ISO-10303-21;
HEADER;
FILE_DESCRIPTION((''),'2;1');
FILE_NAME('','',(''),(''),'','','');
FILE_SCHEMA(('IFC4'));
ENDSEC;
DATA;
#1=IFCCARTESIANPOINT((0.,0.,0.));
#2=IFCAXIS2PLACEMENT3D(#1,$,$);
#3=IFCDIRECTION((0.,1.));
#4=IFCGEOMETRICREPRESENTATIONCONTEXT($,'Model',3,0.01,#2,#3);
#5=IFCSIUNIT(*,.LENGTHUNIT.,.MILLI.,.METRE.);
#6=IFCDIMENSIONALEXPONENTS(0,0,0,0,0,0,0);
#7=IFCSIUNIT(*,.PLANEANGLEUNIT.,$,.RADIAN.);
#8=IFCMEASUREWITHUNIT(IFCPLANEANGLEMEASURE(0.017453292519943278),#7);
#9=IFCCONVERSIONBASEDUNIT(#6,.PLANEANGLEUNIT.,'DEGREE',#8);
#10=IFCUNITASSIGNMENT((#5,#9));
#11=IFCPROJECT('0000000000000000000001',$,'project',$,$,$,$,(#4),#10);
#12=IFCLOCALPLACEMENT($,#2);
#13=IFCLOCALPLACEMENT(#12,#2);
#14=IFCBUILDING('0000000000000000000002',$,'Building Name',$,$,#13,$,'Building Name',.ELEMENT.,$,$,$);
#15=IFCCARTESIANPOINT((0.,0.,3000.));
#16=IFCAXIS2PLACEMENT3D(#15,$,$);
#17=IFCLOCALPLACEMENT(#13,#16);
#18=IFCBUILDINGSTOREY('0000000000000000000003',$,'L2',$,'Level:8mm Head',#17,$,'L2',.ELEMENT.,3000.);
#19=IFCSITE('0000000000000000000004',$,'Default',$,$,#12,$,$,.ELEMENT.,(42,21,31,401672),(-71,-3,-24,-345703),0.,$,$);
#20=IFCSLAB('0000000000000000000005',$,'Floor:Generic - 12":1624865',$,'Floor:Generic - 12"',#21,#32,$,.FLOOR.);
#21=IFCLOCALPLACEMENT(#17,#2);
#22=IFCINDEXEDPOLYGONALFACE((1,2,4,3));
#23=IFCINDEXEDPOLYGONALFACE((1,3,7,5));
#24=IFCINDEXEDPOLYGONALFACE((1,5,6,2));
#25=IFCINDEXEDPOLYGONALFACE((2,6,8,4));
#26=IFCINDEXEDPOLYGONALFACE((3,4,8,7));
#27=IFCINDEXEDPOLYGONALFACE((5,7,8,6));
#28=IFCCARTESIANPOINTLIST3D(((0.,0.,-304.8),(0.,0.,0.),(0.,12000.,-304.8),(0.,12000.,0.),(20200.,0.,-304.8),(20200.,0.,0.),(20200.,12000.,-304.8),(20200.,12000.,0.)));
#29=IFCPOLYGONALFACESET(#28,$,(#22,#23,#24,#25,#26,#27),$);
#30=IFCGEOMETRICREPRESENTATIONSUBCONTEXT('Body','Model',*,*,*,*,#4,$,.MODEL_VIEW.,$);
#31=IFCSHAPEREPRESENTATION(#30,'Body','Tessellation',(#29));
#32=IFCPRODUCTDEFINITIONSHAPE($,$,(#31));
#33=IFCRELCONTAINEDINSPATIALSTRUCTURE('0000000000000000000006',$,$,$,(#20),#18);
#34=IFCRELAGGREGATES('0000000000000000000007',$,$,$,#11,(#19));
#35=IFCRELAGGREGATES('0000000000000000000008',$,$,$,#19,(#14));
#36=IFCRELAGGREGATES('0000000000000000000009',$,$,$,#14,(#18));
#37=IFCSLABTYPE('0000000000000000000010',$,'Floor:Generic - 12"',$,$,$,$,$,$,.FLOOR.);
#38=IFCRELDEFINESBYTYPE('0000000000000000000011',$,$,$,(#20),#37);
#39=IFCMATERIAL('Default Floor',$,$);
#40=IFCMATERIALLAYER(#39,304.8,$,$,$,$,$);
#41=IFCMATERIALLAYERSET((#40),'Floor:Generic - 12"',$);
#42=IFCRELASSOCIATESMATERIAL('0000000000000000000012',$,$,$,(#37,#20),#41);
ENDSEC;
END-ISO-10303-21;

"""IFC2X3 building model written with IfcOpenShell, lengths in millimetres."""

from ifc_helpers import new_model, entity, si_unit, converted_unit, direction, frame, origin, origin_2d_with_axis, place, context, subcontext, project, spatial, rectangle, extrude, material, layer, layer_set, layer_usage, type_object, element, save


model = new_model("IFC2X3")

# Units and contexts
model_context = context("Model", 3, precision=0.01, world=origin(), true_north=direction((0.0, 1.0)))
body_context = subcontext(model_context, "Body", "Model", "MODEL_VIEW")
ifc_project = project(units=[si_unit("LENGTHUNIT", "METRE", prefix="MILLI"), converted_unit("PLANEANGLEUNIT", "DEGREE", entity("IfcPlaneAngleMeasure", 0.017453292519943278), si_unit("PLANEANGLEUNIT", "RADIAN"), dimensions=[0, 0, 0, 0, 0, 0, 0])], contexts=[model_context])

# Site, building, storey
site_placement = place(None, origin())
site = spatial("IfcSite", under=ifc_project, at=site_placement, Name="Default", CompositionType="ELEMENT", RefLatitude=(42, 21, 31, 401672), RefLongitude=(-71, -3, -24, -345703), RefElevation=0.0)
building_placement = place(site_placement, origin())
building = spatial("IfcBuilding", under=site, at=building_placement, Name="Building Name", LongName="Building Name", CompositionType="ELEMENT")
storey_placement = place(building_placement, frame((0.0, 0.0, 3000.0)))
storey = spatial("IfcBuildingStorey", under=building, at=storey_placement, Name="L2", ObjectType="Level:8mm Head", LongName="L2", CompositionType="ELEMENT", Elevation=3000.0)

# Slab
ifc_material = material(Name="Default Floor")
ifc_layer = layer(ifc_material, 304.8)
ifc_layer_set = layer_set([ifc_layer], Name="Floor:Generic - 12\"")
ifc_layer_usage = layer_usage(ifc_layer_set, "AXIS3", "POSITIVE", 0.0)
slab_type = type_object("IfcSlabType", Name="Floor:Generic - 12\"", PredefinedType="FLOOR", material=ifc_layer_set)
slab_placement = place(storey_placement, origin())
element("IfcSlab", 1, at=slab_placement, inside=storey, type_object=slab_type, material=ifc_layer_usage, Name="Floor:Generic - 12\":1624865", ObjectType="Floor:Generic - 12\"", PredefinedType="FLOOR", context=body_context, shape_type="SweptSolid", body=[
    extrude(rectangle(XDim=12000.0, YDim=20200.0, at=origin_2d_with_axis()), frame((10100.0, 6000.0, 0.0), z_axis=(0.0, 0.0, -1.0), x_axis=(0.0, 1.0, 0.0)), (0.0, 0.0, 1.0), 304.8),
])

save(model, "model.ifc")
